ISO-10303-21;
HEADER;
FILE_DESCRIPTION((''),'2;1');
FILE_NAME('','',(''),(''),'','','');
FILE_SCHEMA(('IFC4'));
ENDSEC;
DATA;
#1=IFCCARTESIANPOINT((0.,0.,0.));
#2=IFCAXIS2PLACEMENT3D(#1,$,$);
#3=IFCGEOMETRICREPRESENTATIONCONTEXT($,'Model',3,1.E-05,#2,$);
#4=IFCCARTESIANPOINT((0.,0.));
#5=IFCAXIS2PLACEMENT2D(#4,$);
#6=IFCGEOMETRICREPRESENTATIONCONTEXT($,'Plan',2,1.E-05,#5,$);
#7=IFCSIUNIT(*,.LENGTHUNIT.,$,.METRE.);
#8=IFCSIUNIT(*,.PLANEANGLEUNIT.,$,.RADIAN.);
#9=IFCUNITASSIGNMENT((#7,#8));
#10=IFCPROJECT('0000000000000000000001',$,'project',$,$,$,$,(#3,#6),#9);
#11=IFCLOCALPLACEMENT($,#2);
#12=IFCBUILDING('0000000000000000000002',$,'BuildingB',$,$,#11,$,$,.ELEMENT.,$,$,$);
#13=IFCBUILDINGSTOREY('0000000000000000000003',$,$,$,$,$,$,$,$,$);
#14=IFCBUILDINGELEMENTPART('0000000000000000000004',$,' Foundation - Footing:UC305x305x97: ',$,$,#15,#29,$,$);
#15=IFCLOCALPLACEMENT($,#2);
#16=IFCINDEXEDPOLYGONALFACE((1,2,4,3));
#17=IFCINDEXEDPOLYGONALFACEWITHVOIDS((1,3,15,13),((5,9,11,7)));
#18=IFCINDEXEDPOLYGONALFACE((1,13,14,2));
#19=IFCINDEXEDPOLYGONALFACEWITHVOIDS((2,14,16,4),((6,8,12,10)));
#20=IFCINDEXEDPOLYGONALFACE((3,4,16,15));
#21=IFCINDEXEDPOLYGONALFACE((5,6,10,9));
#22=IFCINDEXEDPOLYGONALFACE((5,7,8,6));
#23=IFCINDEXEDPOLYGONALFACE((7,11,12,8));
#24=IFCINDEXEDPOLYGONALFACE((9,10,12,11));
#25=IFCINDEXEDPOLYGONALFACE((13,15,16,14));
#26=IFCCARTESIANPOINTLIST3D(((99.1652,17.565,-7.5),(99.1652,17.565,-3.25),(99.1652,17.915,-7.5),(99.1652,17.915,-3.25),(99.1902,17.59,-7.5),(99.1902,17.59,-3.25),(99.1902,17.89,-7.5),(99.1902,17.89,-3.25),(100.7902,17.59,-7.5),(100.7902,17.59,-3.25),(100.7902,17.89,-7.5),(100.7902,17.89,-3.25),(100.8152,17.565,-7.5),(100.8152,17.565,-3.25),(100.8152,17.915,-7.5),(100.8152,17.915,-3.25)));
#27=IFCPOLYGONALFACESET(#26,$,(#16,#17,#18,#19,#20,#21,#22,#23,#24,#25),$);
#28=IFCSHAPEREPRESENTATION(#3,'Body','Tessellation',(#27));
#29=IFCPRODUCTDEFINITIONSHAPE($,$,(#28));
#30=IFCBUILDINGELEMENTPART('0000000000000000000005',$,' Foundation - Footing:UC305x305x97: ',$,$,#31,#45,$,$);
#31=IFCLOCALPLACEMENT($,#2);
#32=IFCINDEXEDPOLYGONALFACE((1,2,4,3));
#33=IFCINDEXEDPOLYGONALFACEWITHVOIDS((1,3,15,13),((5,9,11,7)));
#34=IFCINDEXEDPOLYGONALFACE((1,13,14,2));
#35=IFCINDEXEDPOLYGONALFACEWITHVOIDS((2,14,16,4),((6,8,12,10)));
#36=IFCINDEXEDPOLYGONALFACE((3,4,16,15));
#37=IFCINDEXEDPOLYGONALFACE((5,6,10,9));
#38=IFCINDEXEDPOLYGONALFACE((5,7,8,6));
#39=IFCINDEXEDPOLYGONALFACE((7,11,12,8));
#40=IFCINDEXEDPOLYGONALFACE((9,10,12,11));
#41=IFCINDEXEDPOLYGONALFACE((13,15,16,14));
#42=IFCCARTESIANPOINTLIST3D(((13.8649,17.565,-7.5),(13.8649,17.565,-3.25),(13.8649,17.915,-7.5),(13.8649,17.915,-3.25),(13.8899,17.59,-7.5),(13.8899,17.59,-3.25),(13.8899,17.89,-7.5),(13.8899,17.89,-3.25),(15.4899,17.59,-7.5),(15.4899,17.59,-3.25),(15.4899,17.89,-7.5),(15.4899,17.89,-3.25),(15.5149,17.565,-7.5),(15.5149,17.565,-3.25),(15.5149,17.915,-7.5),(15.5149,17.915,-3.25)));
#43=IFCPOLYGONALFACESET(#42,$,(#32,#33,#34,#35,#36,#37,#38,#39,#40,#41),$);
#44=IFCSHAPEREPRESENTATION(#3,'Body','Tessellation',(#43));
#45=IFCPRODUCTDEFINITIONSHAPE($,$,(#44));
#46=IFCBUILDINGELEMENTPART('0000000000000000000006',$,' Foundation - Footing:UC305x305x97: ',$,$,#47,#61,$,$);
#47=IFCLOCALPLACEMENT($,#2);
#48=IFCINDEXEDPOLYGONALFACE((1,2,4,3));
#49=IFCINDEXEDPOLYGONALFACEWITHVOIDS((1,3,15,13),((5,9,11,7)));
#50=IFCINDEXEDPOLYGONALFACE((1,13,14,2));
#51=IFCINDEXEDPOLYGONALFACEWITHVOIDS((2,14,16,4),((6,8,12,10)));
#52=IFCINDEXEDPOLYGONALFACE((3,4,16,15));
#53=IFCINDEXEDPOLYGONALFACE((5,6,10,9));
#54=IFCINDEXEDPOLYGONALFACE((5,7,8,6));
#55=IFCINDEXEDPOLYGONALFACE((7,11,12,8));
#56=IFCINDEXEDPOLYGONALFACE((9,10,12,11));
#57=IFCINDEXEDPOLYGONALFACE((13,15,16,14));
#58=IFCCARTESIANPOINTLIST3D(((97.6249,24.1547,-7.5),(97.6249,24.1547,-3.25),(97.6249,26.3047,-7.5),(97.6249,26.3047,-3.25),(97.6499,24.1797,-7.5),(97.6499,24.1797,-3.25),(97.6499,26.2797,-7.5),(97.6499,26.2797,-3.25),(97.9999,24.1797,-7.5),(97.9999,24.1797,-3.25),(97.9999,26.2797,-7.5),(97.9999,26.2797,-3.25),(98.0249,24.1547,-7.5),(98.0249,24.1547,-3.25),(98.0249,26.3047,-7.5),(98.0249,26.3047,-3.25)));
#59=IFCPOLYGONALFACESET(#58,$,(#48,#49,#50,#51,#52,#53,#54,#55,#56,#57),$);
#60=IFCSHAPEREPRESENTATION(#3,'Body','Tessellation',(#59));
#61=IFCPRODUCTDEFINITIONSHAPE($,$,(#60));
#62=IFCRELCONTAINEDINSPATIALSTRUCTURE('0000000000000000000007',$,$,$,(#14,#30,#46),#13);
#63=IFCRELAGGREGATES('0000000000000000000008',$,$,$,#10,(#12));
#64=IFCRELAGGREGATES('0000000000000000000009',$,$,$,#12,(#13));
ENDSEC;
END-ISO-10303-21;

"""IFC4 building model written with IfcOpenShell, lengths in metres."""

from ifc_helpers import new_model, si_unit, origin, origin_2d, place, context, project, spatial, polyline, outline, extrude, element, save


model = new_model("IFC4")

# Units and contexts
model_context = context("Model", 3, precision=1e-05, world=origin())
plan_context = context("Plan", 2, precision=1e-05, world=origin_2d())
ifc_project = project(units=[si_unit("LENGTHUNIT", "METRE"), si_unit("PLANEANGLEUNIT", "RADIAN")], contexts=[model_context, plan_context])

# Building, storey
building_placement = place(None, origin())
building = spatial("IfcBuilding", under=ifc_project, at=building_placement, Name="BuildingB", CompositionType="ELEMENT")
storey = spatial("IfcBuildingStorey", under=building)

# Building element parts, openings
building_element_part_1 = element("IfcBuildingElementPart", 1, inside=storey, Name=" Foundation - Footing:UC305x305x97: ", context=model_context, shape_type="SweptSolid", body=[
    extrude(outline(polyline([(100.8152, 17.565, -7.5), (100.8152, 17.915, -7.5), (99.1652, 17.915, -7.5), (99.1652, 17.565, -7.5), (100.8152, 17.565, -7.5)])), None, (0.0, 0.0, 1.0), 4.25),
])
element("IfcOpeningElement", 2, inside=storey, cuts=building_element_part_1, context=model_context, shape_type="SweptSolid", body=[
    extrude(outline(polyline([(100.7902, 17.59, -7.5), (100.7902, 17.89, -7.5), (99.1902, 17.89, -7.5), (99.1902, 17.59, -7.5), (100.7902, 17.59, -7.5)])), None, (0.0, 0.0, 1.0), 4.25),
])
building_element_part_2 = element("IfcBuildingElementPart", 3, inside=storey, Name=" Foundation - Footing:UC305x305x97: ", context=model_context, shape_type="SweptSolid", body=[
    extrude(outline(polyline([(13.8649, 17.565, -7.5), (13.8649, 17.915, -7.5), (15.5149, 17.915, -7.5), (15.5149, 17.565, -7.5), (13.8649, 17.565, -7.5)])), None, (0.0, 0.0, 1.0), 4.25),
])
element("IfcOpeningElement", 4, inside=storey, cuts=building_element_part_2, context=model_context, shape_type="SweptSolid", body=[
    extrude(outline(polyline([(13.8899, 17.59, -7.5), (13.8899, 17.89, -7.5), (15.4899, 17.89, -7.5), (15.4899, 17.59, -7.5), (13.8899, 17.59, -7.5)])), None, (0.0, 0.0, 1.0), 4.25),
])
building_element_part_3 = element("IfcBuildingElementPart", 5, inside=storey, Name=" Foundation - Footing:UC305x305x97: ", context=model_context, shape_type="SweptSolid", body=[
    extrude(outline(polyline([(97.6249, 26.3047, -7.5), (98.0249, 26.3047, -7.5), (98.0249, 24.1547, -7.5), (97.6249, 24.1547, -7.5), (97.6249, 26.3047, -7.5)])), None, (0.0, 0.0, 1.0), 4.25),
])
element("IfcOpeningElement", 6, inside=storey, cuts=building_element_part_3, context=model_context, shape_type="SweptSolid", body=[
    extrude(outline(polyline([(97.6499, 26.2797, -7.5), (97.9999, 26.2797, -7.5), (97.9999, 24.1797, -7.5), (97.6499, 24.1797, -7.5), (97.6499, 26.2797, -7.5)])), None, (0.0, 0.0, 1.0), 4.25),
])

save(model, "model.ifc")
